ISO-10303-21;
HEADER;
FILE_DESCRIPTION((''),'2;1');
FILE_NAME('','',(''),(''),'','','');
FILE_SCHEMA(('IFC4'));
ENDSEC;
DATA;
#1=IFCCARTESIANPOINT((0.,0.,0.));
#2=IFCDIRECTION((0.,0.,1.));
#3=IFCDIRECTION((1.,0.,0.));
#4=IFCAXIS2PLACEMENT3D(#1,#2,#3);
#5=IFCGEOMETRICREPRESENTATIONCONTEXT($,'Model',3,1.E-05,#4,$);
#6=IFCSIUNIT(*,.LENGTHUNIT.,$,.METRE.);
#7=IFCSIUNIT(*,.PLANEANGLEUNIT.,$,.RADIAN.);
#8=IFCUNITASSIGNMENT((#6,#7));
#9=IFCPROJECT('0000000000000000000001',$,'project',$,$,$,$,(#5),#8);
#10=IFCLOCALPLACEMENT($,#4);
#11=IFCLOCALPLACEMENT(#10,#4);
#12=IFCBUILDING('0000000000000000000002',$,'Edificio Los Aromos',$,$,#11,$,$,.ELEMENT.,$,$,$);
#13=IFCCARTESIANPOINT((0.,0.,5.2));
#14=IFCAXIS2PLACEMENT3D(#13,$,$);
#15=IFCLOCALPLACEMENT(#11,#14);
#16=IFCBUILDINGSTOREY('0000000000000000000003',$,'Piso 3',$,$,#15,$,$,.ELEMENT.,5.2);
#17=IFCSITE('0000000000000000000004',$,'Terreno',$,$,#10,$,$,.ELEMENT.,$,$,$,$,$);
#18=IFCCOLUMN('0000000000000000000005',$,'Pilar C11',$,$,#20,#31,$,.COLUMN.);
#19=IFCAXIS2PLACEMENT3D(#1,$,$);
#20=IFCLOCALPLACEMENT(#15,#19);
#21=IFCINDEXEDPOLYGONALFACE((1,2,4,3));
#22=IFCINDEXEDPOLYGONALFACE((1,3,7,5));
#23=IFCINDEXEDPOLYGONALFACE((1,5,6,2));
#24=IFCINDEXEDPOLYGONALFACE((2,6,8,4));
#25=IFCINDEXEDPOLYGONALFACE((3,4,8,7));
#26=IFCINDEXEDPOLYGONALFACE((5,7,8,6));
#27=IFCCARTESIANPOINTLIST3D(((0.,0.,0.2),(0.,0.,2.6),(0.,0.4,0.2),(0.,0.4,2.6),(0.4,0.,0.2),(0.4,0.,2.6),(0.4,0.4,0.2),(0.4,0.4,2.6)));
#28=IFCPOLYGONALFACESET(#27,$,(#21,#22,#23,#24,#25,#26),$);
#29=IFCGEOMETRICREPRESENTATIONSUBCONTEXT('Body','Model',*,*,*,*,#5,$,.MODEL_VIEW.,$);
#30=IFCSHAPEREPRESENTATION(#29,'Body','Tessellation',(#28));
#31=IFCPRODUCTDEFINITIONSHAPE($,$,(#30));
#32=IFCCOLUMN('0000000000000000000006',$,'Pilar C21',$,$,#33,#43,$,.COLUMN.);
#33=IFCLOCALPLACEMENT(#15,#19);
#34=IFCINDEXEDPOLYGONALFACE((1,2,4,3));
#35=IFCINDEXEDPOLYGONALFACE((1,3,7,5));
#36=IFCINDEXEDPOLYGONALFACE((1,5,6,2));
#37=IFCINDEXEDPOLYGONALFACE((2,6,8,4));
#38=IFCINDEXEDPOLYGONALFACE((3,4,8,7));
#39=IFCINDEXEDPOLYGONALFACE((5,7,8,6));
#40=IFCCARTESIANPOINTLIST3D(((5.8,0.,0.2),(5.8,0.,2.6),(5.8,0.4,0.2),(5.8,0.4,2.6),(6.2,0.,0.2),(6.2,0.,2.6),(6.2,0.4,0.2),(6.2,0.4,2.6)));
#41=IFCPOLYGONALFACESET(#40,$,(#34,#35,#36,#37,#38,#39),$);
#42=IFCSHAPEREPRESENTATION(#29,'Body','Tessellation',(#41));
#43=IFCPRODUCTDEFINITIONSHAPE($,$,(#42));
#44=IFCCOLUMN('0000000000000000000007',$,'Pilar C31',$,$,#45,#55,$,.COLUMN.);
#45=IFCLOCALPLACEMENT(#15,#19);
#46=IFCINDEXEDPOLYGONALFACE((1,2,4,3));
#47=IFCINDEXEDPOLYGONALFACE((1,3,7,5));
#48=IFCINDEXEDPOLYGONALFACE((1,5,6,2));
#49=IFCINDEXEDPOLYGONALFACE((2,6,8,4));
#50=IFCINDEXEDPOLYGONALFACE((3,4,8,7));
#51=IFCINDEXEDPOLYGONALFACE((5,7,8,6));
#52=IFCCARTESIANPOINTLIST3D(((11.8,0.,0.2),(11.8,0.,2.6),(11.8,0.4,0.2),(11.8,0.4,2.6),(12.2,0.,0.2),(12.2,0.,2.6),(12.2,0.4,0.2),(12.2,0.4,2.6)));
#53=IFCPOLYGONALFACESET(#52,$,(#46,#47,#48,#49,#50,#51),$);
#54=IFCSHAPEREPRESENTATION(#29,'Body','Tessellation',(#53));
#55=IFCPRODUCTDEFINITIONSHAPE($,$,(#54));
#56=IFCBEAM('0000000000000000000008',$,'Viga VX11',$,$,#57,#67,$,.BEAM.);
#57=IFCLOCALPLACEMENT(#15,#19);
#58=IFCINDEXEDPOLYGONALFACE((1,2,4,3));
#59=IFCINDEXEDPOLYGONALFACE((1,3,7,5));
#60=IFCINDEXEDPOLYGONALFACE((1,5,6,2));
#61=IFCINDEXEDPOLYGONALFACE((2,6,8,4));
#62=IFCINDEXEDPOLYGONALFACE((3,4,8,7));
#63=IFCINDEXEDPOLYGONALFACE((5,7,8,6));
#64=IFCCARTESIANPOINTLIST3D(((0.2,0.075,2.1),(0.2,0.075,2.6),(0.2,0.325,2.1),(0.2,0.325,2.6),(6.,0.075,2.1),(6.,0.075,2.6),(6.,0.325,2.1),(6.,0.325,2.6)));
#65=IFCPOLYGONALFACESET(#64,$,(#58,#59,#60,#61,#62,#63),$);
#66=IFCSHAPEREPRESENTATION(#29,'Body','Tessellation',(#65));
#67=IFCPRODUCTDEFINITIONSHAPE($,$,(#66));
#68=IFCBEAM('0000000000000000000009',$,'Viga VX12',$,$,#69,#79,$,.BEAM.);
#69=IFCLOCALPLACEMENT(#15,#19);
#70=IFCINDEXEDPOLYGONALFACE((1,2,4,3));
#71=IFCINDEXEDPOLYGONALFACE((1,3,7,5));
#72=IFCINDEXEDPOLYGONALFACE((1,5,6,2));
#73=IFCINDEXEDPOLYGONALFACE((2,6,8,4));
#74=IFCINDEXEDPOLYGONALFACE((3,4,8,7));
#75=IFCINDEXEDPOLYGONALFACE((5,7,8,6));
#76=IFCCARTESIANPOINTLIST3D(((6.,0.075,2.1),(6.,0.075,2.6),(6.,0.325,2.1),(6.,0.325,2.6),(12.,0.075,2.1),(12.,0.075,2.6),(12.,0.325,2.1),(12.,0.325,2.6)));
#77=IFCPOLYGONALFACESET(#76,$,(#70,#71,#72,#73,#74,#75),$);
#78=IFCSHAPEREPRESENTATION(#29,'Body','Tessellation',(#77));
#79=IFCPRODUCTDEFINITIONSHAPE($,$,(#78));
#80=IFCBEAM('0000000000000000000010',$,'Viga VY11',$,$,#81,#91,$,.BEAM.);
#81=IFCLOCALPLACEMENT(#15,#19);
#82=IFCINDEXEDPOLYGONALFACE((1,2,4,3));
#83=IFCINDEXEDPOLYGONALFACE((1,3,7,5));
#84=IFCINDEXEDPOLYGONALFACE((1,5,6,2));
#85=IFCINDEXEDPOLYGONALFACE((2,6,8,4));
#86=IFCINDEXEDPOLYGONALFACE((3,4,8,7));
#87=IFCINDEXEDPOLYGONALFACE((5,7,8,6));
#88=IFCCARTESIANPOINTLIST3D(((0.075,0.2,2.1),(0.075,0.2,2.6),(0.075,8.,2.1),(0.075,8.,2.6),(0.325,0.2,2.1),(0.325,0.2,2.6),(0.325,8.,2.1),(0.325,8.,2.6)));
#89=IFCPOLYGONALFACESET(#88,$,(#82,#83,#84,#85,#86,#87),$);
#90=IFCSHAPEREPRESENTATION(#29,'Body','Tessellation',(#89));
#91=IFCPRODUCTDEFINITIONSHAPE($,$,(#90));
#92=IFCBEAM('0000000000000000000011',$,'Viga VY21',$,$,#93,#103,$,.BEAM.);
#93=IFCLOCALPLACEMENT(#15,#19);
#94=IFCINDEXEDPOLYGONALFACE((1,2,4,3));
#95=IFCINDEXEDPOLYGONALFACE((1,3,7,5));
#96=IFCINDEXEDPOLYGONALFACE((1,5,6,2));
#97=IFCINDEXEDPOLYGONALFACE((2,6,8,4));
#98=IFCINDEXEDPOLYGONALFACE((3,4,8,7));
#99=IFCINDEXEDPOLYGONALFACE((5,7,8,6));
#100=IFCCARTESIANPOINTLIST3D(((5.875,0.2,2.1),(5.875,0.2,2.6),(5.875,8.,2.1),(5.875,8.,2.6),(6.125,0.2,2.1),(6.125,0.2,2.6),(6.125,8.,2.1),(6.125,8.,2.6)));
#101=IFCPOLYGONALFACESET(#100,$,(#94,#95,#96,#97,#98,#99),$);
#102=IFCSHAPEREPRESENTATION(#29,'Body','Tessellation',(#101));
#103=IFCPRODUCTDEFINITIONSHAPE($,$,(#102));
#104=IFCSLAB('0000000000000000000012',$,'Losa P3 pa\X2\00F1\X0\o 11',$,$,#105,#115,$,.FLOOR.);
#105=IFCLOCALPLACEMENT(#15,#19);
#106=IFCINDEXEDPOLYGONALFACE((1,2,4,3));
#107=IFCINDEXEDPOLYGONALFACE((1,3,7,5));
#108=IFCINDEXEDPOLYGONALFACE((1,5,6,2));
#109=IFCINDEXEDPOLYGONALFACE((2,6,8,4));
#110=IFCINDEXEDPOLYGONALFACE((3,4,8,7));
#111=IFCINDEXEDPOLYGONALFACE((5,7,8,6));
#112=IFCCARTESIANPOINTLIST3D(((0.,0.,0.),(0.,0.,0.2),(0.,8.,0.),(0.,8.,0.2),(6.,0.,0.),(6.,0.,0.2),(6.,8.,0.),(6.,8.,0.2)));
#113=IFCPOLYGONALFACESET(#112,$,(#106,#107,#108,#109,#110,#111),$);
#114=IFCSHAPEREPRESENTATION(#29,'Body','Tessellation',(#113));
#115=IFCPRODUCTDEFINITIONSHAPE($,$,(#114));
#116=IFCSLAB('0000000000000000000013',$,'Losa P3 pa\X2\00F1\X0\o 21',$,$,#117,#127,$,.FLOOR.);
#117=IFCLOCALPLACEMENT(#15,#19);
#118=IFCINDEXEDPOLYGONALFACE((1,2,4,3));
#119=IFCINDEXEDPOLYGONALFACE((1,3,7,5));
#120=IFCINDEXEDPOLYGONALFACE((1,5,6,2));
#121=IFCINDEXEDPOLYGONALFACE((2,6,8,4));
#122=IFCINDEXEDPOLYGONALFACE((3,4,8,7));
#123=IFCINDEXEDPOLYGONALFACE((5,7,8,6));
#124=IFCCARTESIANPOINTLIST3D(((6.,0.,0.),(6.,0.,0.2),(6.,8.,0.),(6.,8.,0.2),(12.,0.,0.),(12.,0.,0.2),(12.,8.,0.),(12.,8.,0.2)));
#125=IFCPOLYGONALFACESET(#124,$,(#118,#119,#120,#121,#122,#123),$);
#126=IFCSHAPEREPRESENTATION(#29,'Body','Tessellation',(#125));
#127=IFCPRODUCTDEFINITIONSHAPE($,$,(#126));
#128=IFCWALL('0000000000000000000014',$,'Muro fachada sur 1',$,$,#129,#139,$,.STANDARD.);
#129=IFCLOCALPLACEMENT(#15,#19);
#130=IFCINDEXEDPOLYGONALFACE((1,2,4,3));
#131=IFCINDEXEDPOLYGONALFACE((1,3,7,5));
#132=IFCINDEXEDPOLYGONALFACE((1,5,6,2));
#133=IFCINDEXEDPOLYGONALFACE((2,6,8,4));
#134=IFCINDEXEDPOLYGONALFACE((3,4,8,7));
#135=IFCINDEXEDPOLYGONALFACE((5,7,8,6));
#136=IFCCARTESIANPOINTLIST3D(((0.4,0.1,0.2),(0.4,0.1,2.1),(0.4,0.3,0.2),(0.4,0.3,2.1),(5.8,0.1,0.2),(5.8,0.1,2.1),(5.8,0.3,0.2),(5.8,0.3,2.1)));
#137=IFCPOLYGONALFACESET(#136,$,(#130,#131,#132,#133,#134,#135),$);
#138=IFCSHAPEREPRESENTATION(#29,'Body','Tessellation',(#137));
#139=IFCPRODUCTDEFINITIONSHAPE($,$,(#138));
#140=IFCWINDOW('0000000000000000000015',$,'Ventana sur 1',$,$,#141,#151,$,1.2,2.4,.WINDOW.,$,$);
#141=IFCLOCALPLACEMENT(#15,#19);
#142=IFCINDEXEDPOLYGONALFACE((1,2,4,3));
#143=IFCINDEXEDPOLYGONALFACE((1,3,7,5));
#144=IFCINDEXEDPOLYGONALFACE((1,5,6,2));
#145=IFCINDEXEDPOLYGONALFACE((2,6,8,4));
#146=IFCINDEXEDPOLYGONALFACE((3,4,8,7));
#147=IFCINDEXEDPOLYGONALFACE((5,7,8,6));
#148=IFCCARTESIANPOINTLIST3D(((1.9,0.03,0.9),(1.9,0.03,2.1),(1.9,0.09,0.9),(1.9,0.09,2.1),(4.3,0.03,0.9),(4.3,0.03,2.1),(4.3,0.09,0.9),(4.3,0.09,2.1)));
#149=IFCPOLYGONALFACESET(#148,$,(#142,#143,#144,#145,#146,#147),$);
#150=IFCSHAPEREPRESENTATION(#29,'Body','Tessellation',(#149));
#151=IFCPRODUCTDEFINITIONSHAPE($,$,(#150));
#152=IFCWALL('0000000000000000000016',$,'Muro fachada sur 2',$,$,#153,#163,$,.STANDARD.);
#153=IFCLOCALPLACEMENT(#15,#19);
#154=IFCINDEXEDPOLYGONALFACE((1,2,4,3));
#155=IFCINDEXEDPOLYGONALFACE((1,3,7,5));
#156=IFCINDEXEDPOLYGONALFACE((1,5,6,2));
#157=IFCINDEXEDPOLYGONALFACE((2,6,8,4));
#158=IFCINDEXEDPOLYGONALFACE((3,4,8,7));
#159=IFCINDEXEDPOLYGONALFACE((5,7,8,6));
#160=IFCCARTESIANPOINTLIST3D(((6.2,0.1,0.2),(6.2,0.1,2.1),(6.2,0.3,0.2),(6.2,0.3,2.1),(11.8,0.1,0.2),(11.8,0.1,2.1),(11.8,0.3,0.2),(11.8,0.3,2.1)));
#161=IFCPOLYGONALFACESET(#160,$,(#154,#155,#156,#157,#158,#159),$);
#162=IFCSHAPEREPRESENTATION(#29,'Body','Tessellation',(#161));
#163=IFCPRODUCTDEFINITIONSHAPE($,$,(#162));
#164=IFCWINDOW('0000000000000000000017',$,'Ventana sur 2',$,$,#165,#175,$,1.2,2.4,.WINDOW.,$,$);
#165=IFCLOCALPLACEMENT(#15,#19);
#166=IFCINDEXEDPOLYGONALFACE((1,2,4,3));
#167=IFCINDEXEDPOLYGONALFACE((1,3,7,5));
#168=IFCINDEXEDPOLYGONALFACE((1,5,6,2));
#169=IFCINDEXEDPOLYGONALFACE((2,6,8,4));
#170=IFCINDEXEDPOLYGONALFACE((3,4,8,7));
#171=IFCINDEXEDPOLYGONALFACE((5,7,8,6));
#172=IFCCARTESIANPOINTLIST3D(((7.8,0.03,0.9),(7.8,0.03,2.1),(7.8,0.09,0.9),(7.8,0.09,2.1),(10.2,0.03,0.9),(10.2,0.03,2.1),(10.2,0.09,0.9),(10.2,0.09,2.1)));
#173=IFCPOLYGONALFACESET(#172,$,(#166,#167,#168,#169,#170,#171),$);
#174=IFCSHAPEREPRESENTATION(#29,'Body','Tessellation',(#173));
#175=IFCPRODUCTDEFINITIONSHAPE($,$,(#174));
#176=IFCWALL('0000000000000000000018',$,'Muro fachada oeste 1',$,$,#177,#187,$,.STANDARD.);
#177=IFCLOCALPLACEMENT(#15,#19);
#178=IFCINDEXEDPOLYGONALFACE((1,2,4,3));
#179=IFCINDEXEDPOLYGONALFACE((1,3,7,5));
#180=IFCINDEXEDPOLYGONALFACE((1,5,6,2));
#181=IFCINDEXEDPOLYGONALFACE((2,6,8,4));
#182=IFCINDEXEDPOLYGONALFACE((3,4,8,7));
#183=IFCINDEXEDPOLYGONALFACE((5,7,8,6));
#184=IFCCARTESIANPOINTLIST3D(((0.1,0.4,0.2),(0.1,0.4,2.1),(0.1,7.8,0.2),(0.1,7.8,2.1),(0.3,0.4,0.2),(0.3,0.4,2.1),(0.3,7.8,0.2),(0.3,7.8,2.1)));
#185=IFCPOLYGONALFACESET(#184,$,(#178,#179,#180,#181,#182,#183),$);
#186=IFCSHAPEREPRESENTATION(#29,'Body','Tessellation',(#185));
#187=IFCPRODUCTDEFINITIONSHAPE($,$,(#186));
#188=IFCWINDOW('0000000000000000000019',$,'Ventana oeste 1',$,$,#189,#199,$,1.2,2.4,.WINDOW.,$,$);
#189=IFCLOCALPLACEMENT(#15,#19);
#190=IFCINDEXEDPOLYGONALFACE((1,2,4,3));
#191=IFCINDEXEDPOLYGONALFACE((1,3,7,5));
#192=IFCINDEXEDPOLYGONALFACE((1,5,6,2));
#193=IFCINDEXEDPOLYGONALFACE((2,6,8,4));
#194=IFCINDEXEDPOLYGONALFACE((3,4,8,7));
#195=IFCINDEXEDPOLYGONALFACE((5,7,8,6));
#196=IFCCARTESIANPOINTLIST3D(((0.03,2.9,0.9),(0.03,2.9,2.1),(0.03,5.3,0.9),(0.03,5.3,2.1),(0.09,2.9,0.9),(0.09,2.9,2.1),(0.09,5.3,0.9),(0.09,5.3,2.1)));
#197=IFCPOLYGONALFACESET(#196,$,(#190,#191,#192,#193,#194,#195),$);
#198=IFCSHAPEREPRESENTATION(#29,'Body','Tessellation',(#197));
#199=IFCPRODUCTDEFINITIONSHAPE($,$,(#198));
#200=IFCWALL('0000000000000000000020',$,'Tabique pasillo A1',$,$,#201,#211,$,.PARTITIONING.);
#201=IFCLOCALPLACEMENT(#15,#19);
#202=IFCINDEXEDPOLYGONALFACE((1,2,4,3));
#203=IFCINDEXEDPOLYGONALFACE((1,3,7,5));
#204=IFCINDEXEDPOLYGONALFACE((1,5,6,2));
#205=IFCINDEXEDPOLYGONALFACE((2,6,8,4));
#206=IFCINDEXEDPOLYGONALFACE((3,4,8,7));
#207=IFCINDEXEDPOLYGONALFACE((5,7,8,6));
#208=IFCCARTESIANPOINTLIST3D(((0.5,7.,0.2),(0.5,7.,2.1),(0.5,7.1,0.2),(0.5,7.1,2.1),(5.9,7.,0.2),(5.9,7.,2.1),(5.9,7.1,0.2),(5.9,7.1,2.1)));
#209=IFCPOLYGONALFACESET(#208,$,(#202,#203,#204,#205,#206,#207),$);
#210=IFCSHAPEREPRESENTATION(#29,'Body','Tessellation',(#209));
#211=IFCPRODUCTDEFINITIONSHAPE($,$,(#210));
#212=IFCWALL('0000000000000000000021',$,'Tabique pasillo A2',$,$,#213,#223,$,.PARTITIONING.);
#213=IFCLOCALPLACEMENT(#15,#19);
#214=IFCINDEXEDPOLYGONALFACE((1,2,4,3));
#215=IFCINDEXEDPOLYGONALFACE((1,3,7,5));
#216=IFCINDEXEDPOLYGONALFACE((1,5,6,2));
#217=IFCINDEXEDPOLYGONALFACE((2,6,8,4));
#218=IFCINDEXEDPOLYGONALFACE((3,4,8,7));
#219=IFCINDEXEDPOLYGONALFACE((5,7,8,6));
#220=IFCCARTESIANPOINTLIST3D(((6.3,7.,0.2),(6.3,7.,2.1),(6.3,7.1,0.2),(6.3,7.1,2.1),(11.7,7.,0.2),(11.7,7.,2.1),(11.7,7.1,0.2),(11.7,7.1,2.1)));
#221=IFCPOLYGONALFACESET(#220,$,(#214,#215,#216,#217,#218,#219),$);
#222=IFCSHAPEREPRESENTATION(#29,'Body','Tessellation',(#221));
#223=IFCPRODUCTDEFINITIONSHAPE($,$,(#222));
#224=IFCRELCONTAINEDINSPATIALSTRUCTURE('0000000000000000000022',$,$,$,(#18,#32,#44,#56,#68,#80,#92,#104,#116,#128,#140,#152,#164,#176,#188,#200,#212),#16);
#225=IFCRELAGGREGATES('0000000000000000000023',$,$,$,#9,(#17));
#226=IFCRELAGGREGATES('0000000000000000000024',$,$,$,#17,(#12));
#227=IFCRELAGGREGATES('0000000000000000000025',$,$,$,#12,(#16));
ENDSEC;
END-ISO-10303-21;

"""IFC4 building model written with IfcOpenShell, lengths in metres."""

from ifc_helpers import new_model, si_unit, frame, frame_2d, origin_with_axes, place, context, subcontext, project, spatial, rectangle, extrude, element, save


model = new_model("IFC4")

# Units and contexts
model_context = context("Model", 3, precision=1e-05, world=origin_with_axes())
body_context = subcontext(model_context, "Body", "Model", "MODEL_VIEW")
ifc_project = project(units=[si_unit("LENGTHUNIT", "METRE"), si_unit("PLANEANGLEUNIT", "RADIAN")], contexts=[model_context])

# Site, building, storey
site_placement = place(None, origin_with_axes())
site = spatial("IfcSite", under=ifc_project, at=site_placement, Name="Terreno", CompositionType="ELEMENT")
building_placement = place(site_placement, origin_with_axes())
building = spatial("IfcBuilding", under=site, at=building_placement, Name="Edificio Los Aromos", CompositionType="ELEMENT")
storey_placement = place(building_placement, frame((0.0, 0.0, 5.2)))
storey = spatial("IfcBuildingStorey", under=building, at=storey_placement, Name="Piso 3", CompositionType="ELEMENT", Elevation=5.2)

# Columns
for number, where, name in (
    (1, (0.0, 0.0, 0.2), "Pilar C11"),
    (2, (5.8, 0.0, 0.2), "Pilar C21"),
    (3, (11.8, 0.0, 0.2), "Pilar C31"),
):
    element("IfcColumn", number, at=place(storey_placement, frame(where)), inside=storey, Name=name, PredefinedType="COLUMN", context=body_context, shape_type="SweptSolid", body=[
        extrude(rectangle(XDim=0.4, YDim=0.4, at=frame_2d((0.2, 0.2))), origin_with_axes(), (0.0, 0.0, 1.0), 2.4),
    ])

# Beams
beam_1_placement = place(storey_placement, frame((0.2, 0.075, 2.1)))
element("IfcBeam", 4, at=beam_1_placement, inside=storey, Name="Viga VX11", PredefinedType="BEAM", context=body_context, shape_type="SweptSolid", body=[
    extrude(rectangle(XDim=5.8, YDim=0.25, at=frame_2d((2.9, 0.125))), origin_with_axes(), (0.0, 0.0, 1.0), 0.5),
])
beam_2_placement = place(storey_placement, frame((6.0, 0.075, 2.1)))
element("IfcBeam", 5, at=beam_2_placement, inside=storey, Name="Viga VX12", PredefinedType="BEAM", context=body_context, shape_type="SweptSolid", body=[
    extrude(rectangle(XDim=6.0, YDim=0.25, at=frame_2d((3.0, 0.125))), origin_with_axes(), (0.0, 0.0, 1.0), 0.5),
])
for number, where, name in (
    (6, (0.075, 0.2, 2.1), "Viga VY11"),
    (7, (5.875, 0.2, 2.1), "Viga VY21"),
):
    element("IfcBeam", number, at=place(storey_placement, frame(where)), inside=storey, Name=name, PredefinedType="BEAM", context=body_context, shape_type="SweptSolid", body=[
        extrude(rectangle(XDim=0.25, YDim=7.8, at=frame_2d((0.125, 3.9))), origin_with_axes(), (0.0, 0.0, 1.0), 0.5),
    ])

# Slabs
for number, where, name in (
    (8, (0.0, 0.0, 0.0), "Losa P3 paño 11"),
    (9, (6.0, 0.0, 0.0), "Losa P3 paño 21"),
):
    element("IfcSlab", number, at=place(storey_placement, frame(where)), inside=storey, Name=name, PredefinedType="FLOOR", context=body_context, shape_type="SweptSolid", body=[
        extrude(rectangle(XDim=6.0, YDim=8.0, at=frame_2d((3.0, 4.0))), origin_with_axes(), (0.0, 0.0, 1.0), 0.2),
    ])

# Wall
wall_1_placement = place(storey_placement, frame((0.4, 0.1, 0.2)))
element("IfcWall", 10, at=wall_1_placement, inside=storey, Name="Muro fachada sur 1", PredefinedType="STANDARD", context=body_context, shape_type="SweptSolid", body=[
    extrude(rectangle(XDim=5.4, YDim=0.2, at=frame_2d((2.7, 0.1))), origin_with_axes(), (0.0, 0.0, 1.0), 1.9),
])

# Window
window_1_placement = place(storey_placement, frame((1.9, 0.03, 0.9)))
element("IfcWindow", 11, at=window_1_placement, inside=storey, Name="Ventana sur 1", OverallHeight=1.2, OverallWidth=2.4, PredefinedType="WINDOW", context=body_context, shape_type="SweptSolid", body=[
    extrude(rectangle(XDim=2.4, YDim=0.06, at=frame_2d((1.2, 0.03))), origin_with_axes(), (0.0, 0.0, 1.0), 1.2),
])

# Wall
wall_2_placement = place(storey_placement, frame((6.2, 0.1, 0.2)))
element("IfcWall", 12, at=wall_2_placement, inside=storey, Name="Muro fachada sur 2", PredefinedType="STANDARD", context=body_context, shape_type="SweptSolid", body=[
    extrude(rectangle(XDim=5.6, YDim=0.2, at=frame_2d((2.8, 0.1))), origin_with_axes(), (0.0, 0.0, 1.0), 1.9),
])

# Window
window_2_placement = place(storey_placement, frame((7.8, 0.03, 0.9)))
element("IfcWindow", 13, at=window_2_placement, inside=storey, Name="Ventana sur 2", OverallHeight=1.2, OverallWidth=2.4, PredefinedType="WINDOW", context=body_context, shape_type="SweptSolid", body=[
    extrude(rectangle(XDim=2.4, YDim=0.06, at=frame_2d((1.2, 0.03))), origin_with_axes(), (0.0, 0.0, 1.0), 1.2),
])

# Wall
wall_3_placement = place(storey_placement, frame((0.1, 0.4, 0.2)))
element("IfcWall", 14, at=wall_3_placement, inside=storey, Name="Muro fachada oeste 1", PredefinedType="STANDARD", context=body_context, shape_type="SweptSolid", body=[
    extrude(rectangle(XDim=0.2, YDim=7.4, at=frame_2d((0.1, 3.7))), origin_with_axes(), (0.0, 0.0, 1.0), 1.9),
])

# Window
window_3_placement = place(storey_placement, frame((0.03, 2.9, 0.9)))
element("IfcWindow", 15, at=window_3_placement, inside=storey, Name="Ventana oeste 1", OverallHeight=1.2, OverallWidth=2.4, PredefinedType="WINDOW", context=body_context, shape_type="SweptSolid", body=[
    extrude(rectangle(XDim=0.06, YDim=2.4, at=frame_2d((0.03, 1.2))), origin_with_axes(), (0.0, 0.0, 1.0), 1.2),
])

# Walls
for number, where, name in (
    (16, (0.5, 7.0, 0.2), "Tabique pasillo A1"),
    (17, (6.3, 7.0, 0.2), "Tabique pasillo A2"),
):
    element("IfcWall", number, at=place(storey_placement, frame(where)), inside=storey, Name=name, PredefinedType="PARTITIONING", context=body_context, shape_type="SweptSolid", body=[
        extrude(rectangle(XDim=5.4, YDim=0.1, at=frame_2d((2.7, 0.05))), origin_with_axes(), (0.0, 0.0, 1.0), 1.9),
    ])

save(model, "model.ifc")
